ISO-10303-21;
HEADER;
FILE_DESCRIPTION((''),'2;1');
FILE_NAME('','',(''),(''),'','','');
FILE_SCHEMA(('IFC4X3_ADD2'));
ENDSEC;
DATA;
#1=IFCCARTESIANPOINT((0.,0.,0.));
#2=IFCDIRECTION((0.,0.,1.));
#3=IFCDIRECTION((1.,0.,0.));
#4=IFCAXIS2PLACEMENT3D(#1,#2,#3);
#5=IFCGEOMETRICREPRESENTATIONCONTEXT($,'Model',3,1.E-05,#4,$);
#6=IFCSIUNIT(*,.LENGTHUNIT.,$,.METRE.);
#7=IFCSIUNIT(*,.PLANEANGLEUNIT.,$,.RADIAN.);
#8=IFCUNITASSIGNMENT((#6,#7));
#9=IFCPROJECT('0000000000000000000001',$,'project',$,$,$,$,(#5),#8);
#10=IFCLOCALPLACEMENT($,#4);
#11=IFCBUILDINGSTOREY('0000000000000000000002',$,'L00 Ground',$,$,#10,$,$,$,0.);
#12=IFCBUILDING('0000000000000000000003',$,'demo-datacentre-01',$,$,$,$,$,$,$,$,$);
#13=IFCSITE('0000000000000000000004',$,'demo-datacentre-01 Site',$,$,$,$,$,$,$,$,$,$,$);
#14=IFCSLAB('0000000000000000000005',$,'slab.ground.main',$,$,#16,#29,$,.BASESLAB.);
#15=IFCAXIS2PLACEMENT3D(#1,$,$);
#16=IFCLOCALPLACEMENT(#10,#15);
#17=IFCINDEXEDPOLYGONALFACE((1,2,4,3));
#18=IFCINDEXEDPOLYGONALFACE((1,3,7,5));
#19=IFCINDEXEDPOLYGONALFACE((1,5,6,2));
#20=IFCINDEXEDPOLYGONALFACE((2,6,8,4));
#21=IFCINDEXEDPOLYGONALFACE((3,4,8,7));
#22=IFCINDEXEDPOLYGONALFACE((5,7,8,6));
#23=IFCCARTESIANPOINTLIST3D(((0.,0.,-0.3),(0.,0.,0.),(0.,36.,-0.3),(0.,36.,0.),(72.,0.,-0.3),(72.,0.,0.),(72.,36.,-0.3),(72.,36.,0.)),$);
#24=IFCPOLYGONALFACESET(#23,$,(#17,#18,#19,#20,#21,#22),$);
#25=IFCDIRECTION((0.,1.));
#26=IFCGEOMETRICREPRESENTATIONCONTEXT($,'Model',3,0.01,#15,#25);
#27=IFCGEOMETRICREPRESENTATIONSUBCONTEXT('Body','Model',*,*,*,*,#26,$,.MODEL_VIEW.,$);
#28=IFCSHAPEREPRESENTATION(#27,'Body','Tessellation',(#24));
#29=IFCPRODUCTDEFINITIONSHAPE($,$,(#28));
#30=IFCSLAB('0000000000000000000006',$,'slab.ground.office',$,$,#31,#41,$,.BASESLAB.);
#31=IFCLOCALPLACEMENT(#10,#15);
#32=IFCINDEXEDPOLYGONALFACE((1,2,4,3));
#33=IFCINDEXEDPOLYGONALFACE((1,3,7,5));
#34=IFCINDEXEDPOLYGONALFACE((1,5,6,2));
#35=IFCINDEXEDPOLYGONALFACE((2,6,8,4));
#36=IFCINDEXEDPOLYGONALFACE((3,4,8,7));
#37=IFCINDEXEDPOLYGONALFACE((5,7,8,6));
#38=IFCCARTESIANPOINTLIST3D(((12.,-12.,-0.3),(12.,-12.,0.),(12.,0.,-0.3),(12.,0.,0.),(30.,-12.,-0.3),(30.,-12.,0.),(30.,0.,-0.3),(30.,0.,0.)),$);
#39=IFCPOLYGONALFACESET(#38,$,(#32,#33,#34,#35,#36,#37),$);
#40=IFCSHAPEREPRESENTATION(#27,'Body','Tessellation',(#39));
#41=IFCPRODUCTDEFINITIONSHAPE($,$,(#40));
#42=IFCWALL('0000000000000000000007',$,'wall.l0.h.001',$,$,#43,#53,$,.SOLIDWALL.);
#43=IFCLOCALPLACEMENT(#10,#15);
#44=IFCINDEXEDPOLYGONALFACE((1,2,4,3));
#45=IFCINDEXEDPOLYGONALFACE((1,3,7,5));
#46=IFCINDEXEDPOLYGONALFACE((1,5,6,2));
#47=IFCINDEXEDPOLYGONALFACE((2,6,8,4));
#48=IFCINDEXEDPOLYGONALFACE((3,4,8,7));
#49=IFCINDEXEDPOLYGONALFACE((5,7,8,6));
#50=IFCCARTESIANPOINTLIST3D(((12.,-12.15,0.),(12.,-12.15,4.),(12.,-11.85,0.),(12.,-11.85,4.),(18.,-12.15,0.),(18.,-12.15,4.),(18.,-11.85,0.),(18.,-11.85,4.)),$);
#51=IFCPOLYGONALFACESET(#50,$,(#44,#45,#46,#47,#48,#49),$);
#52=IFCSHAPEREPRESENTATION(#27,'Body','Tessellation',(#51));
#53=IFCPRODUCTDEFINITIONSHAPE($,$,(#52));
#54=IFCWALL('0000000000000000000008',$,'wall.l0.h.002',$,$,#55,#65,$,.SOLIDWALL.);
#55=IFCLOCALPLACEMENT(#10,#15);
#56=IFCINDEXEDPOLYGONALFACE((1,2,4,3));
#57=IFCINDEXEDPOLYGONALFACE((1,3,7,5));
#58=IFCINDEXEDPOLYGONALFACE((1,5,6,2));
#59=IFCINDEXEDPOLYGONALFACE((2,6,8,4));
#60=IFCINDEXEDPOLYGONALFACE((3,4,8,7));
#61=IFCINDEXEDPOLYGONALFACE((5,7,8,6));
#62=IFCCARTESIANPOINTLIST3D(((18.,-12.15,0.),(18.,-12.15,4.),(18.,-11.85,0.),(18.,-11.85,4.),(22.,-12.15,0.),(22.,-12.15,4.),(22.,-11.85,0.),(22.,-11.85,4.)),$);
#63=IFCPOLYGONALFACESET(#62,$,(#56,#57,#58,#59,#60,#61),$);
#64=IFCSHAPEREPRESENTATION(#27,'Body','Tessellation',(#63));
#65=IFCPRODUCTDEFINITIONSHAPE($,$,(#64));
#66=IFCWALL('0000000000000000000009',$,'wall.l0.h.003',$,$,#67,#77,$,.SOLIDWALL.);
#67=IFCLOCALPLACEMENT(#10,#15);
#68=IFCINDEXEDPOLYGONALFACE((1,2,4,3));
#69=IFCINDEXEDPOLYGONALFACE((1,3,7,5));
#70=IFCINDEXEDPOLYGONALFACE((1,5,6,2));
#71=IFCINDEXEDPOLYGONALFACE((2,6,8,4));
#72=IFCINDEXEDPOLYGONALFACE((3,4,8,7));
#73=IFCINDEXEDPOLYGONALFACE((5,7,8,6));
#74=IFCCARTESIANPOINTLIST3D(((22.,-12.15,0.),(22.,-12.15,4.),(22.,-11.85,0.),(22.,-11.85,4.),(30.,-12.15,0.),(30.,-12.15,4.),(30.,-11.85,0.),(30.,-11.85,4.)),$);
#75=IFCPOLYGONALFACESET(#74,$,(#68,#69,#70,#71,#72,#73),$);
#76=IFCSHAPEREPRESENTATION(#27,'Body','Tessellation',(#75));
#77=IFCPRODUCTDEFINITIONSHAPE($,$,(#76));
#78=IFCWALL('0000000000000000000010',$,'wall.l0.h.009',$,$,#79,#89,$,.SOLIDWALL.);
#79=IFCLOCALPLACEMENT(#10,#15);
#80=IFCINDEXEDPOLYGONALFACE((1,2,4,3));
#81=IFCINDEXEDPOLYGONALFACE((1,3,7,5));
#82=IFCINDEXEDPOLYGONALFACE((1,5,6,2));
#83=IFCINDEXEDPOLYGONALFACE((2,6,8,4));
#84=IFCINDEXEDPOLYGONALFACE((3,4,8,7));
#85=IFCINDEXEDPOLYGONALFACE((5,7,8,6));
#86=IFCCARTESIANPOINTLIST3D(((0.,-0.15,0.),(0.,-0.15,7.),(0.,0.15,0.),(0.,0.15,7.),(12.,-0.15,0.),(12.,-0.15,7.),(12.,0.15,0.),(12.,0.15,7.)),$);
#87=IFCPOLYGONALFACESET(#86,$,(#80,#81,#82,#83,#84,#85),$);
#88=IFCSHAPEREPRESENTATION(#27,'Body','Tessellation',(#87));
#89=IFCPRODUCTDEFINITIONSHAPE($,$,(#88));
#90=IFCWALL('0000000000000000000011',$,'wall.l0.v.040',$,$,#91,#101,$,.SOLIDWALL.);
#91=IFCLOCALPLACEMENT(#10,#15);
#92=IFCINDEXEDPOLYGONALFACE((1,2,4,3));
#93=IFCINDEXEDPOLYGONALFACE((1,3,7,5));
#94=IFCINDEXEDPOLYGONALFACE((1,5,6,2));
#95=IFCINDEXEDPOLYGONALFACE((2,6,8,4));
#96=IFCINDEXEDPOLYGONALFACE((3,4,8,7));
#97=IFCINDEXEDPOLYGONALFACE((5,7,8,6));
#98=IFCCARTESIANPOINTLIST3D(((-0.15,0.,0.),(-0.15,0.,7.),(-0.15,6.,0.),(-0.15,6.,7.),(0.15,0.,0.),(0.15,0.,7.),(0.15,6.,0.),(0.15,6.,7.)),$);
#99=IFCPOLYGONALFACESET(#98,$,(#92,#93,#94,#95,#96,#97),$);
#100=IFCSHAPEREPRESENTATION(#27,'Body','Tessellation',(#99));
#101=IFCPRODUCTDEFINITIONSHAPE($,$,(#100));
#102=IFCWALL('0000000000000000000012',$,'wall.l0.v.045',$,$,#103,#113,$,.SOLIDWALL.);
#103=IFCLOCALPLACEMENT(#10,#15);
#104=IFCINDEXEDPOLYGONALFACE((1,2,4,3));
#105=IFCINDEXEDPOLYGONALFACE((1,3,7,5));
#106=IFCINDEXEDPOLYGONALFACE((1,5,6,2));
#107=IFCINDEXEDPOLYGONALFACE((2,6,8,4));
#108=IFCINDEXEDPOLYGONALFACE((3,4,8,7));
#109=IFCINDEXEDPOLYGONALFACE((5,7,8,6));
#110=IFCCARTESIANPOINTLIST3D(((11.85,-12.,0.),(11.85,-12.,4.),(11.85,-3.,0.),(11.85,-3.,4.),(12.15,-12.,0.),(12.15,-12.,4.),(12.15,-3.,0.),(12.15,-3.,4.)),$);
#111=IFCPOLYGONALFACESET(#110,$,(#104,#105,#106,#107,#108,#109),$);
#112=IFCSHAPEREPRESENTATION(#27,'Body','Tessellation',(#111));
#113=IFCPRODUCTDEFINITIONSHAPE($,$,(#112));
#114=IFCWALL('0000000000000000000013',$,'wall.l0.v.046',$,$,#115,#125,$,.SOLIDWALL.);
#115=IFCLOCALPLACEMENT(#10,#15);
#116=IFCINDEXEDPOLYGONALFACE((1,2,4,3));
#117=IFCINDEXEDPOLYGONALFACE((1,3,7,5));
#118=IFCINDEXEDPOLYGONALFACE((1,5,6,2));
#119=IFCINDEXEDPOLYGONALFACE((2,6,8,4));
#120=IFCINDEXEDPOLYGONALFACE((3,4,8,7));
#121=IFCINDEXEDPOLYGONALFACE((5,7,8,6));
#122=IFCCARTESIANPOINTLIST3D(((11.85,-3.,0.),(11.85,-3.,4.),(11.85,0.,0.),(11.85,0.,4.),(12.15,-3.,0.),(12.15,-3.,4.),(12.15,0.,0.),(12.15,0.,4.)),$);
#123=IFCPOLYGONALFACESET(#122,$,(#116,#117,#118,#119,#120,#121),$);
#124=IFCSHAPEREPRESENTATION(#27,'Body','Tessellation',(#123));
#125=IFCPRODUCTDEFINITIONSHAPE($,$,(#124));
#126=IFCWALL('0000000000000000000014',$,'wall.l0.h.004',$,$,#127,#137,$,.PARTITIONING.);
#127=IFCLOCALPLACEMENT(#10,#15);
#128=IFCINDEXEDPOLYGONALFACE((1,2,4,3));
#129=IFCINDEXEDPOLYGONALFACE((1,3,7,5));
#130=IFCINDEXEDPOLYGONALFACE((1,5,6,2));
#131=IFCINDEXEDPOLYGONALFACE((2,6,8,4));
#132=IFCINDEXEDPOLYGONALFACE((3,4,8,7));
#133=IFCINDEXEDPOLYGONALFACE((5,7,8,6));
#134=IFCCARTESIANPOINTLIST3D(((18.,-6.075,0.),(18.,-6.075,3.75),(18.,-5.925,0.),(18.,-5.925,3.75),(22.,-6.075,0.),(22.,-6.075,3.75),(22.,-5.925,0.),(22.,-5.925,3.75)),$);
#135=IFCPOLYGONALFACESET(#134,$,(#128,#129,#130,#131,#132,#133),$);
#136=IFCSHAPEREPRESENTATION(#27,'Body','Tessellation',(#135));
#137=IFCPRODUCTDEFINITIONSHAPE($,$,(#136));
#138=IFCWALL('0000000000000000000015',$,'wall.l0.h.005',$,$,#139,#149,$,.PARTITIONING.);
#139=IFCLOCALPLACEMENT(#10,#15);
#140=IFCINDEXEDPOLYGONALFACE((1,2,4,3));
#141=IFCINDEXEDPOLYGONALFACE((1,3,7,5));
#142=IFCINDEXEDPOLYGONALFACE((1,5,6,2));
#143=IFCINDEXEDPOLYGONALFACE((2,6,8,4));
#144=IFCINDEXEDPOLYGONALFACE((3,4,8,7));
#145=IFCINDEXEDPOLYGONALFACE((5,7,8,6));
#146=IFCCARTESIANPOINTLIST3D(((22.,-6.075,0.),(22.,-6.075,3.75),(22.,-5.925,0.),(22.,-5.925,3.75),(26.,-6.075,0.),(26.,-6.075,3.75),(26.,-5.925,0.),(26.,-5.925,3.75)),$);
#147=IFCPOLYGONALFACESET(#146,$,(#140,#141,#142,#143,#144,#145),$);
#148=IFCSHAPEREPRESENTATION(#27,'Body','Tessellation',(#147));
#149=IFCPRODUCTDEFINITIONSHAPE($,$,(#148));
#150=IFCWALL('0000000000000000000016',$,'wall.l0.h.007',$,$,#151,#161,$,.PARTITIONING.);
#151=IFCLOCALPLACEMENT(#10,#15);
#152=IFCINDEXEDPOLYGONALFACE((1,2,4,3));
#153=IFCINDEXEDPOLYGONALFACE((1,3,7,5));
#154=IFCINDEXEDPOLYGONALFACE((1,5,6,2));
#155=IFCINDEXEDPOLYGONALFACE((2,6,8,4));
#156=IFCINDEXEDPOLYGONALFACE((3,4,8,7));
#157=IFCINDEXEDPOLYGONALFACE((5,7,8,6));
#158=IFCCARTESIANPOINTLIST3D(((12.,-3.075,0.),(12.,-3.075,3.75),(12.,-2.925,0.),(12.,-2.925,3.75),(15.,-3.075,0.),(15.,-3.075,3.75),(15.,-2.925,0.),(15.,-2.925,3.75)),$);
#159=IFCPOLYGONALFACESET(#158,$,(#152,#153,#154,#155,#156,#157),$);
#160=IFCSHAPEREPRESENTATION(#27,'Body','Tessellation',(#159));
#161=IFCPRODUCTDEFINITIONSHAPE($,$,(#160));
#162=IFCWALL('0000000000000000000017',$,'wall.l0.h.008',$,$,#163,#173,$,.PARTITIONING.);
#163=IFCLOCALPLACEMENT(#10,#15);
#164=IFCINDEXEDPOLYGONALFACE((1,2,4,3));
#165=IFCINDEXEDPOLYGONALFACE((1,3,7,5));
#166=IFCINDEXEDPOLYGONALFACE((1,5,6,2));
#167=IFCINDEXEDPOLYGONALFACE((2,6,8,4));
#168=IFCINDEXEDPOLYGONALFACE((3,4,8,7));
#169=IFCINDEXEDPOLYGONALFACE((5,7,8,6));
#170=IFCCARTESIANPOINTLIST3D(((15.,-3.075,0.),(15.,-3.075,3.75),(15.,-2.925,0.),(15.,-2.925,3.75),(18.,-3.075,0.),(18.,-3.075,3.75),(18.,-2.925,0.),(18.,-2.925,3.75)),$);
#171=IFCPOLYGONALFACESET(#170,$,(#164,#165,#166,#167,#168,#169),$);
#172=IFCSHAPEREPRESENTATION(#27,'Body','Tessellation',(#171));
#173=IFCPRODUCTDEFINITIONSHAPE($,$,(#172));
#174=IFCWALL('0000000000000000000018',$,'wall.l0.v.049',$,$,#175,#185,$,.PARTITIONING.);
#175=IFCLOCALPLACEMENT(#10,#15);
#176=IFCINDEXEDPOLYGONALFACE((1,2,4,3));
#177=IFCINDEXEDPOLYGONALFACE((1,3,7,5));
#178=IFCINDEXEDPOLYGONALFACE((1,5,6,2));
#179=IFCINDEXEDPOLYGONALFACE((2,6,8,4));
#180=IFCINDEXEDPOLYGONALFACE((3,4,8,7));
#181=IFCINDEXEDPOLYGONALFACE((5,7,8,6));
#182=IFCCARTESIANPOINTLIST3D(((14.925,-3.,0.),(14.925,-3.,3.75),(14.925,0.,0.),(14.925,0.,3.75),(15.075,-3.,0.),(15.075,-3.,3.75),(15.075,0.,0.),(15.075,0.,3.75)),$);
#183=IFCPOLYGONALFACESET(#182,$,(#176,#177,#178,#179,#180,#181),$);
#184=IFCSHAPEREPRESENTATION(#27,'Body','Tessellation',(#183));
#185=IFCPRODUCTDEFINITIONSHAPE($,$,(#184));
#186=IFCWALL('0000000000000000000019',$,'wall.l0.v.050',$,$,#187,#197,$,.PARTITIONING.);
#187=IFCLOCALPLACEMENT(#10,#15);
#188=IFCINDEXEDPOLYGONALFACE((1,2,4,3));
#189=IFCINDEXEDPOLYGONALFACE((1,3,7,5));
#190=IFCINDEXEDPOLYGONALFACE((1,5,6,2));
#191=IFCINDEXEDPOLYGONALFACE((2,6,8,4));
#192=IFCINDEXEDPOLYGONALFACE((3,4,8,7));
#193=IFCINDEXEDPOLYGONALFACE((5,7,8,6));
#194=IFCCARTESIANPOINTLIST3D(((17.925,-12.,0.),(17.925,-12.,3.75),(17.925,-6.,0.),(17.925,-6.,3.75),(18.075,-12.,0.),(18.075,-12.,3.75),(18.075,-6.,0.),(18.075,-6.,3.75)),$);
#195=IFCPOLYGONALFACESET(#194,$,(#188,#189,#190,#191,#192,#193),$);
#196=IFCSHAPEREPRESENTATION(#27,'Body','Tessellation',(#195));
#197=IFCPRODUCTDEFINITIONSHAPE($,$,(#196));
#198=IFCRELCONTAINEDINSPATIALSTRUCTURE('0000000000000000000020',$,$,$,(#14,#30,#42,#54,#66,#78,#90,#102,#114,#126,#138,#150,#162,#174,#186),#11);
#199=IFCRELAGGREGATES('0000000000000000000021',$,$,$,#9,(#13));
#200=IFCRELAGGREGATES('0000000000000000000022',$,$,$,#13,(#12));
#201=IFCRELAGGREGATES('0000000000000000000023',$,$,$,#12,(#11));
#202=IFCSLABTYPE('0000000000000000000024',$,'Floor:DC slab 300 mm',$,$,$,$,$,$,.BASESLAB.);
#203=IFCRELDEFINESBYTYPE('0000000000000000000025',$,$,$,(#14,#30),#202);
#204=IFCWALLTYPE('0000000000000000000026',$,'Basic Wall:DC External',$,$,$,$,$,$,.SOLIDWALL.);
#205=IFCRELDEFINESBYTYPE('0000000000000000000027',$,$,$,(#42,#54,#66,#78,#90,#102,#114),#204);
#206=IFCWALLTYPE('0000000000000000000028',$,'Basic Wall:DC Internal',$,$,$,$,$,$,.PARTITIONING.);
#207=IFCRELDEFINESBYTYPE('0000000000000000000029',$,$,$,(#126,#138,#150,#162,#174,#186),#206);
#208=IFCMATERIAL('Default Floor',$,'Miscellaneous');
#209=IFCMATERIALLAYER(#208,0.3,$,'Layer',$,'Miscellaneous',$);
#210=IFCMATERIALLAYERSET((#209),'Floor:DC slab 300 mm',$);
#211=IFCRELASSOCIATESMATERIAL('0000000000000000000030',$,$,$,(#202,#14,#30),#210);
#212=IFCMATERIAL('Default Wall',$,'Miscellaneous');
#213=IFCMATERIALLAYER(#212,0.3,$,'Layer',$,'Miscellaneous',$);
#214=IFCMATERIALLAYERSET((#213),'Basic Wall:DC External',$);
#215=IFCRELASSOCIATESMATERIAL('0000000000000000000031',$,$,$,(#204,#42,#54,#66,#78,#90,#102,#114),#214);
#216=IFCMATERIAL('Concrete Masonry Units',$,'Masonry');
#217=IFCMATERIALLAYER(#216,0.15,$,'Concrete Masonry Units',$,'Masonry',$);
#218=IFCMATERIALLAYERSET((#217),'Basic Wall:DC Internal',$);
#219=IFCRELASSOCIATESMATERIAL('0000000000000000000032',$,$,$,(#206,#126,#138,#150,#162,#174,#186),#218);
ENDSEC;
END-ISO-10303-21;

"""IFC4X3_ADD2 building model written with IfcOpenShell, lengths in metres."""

from ifc_helpers import new_model, si_unit, direction, frame, frame_2d, origin, origin_with_axes, origin_2d_with_axis, place, context, subcontext, project, spatial, rectangle, extrude, material, layer, layer_set, layer_usage, type_object, element, save


model = new_model("IFC4X3_ADD2")

# Units and contexts
model_context_1 = context("Model", 3, precision=0.01, world=origin(), true_north=direction((0.0, 1.0)))
model_context_2 = context("Model", 3, precision=1e-05, world=origin_with_axes())
body_context = subcontext(model_context_1, "Body", "Model", "MODEL_VIEW")
ifc_project = project(units=[si_unit("LENGTHUNIT", "METRE"), si_unit("PLANEANGLEUNIT", "RADIAN")], contexts=[model_context_2])

# Site, building, storey
site = spatial("IfcSite", under=ifc_project, Name="demo-datacentre-01 Site")
building = spatial("IfcBuilding", under=site, Name="demo-datacentre-01")
storey_placement = place(None, origin_with_axes())
storey = spatial("IfcBuildingStorey", under=building, at=storey_placement, Name="L00 Ground", Elevation=0.0)

# Slabs
ifc_material_1 = material(Name="Default Floor", Category="Miscellaneous")
ifc_layer_1 = layer(ifc_material_1, 0.3, Name="Layer", Category="Miscellaneous")
ifc_layer_set_1 = layer_set([ifc_layer_1], Name="Floor:DC slab 300 mm")
ifc_layer_usage_1 = layer_usage(ifc_layer_set_1, "AXIS3", "POSITIVE", 0.0)
slab_type = type_object("IfcSlabType", Name="Floor:DC slab 300 mm", PredefinedType="BASESLAB", material=ifc_layer_set_1)
placement_1 = place(None, origin())
placement_2 = place(placement_1, origin())
placement_3 = place(placement_2, origin())
slab_1_placement = place(placement_3, origin())
element("IfcSlab", 1, at=slab_1_placement, inside=storey, type_object=slab_type, material=ifc_layer_usage_1, Name="slab.ground.main", PredefinedType="BASESLAB", context=body_context, shape_type="SweptSolid", body=[
    extrude(rectangle(XDim=36.0, YDim=72.0, at=origin_2d_with_axis()), frame((36.0, 18.0, 0.0), z_axis=(0.0, 0.0, -1.0), x_axis=(0.0, 1.0, 0.0)), (0.0, 0.0, 1.0), 0.3),
])
ifc_layer_usage_2 = layer_usage(ifc_layer_set_1, "AXIS3", "POSITIVE", 0.0)
slab_2_placement = place(placement_3, origin())
element("IfcSlab", 2, at=slab_2_placement, inside=storey, type_object=slab_type, material=ifc_layer_usage_2, Name="slab.ground.office", PredefinedType="BASESLAB", context=body_context, shape_type="SweptSolid", body=[
    extrude(rectangle(XDim=12.0, YDim=18.0, at=frame_2d((0.0, 0.0), x_axis=(1.0, 0.0))), frame((21.0, -6.0, 0.0), z_axis=(0.0, 0.0, -1.0), x_axis=(0.0, 1.0, 0.0)), (0.0, 0.0, 1.0), 0.3),
])

# Walls
ifc_material_2 = material(Name="Default Wall", Category="Miscellaneous")
ifc_layer_2 = layer(ifc_material_2, 0.3, Name="Layer", Category="Miscellaneous")
ifc_layer_set_2 = layer_set([ifc_layer_2], Name="Basic Wall:DC External")
wall_type_1 = type_object("IfcWallType", Name="Basic Wall:DC External", PredefinedType="SOLIDWALL", material=ifc_layer_set_2)
wall_1_placement = place(placement_3, frame((12.0, -12.0, 0.0)))
element("IfcWall", 3, at=wall_1_placement, inside=storey, type_object=wall_type_1, material=ifc_layer_set_2, Name="wall.l0.h.001", PredefinedType="SOLIDWALL", context=body_context, shape_type="SweptSolid", body=[
    extrude(rectangle(XDim=6.0, YDim=0.3, at=frame_2d((3.0, 0.0), x_axis=(-1.0, 0.0))), origin(), (0.0, 0.0, 1.0), 4.0),
])
wall_2_placement = place(placement_3, frame((18.0, -12.0, 0.0)))
element("IfcWall", 4, at=wall_2_placement, inside=storey, type_object=wall_type_1, material=ifc_layer_set_2, Name="wall.l0.h.002", PredefinedType="SOLIDWALL", context=body_context, shape_type="SweptSolid", body=[
    extrude(rectangle(XDim=4.0, YDim=0.3, at=frame_2d((2.0, 0.0), x_axis=(-1.0, 0.0))), origin(), (0.0, 0.0, 1.0), 4.0),
])
wall_3_placement = place(placement_3, frame((22.0, -12.0, 0.0)))
element("IfcWall", 5, at=wall_3_placement, inside=storey, type_object=wall_type_1, material=ifc_layer_set_2, Name="wall.l0.h.003", PredefinedType="SOLIDWALL", context=body_context, shape_type="SweptSolid", body=[
    extrude(rectangle(XDim=8.0, YDim=0.3, at=frame_2d((4.0, 0.0), x_axis=(-1.0, 0.0))), origin(), (0.0, 0.0, 1.0), 4.0),
])
wall_4_placement = place(placement_3, origin())
element("IfcWall", 6, at=wall_4_placement, inside=storey, type_object=wall_type_1, material=ifc_layer_set_2, Name="wall.l0.h.009", PredefinedType="SOLIDWALL", context=body_context, shape_type="SweptSolid", body=[
    extrude(rectangle(XDim=12.0, YDim=0.3, at=frame_2d((6.0, 0.0), x_axis=(-1.0, 0.0))), origin(), (0.0, 0.0, 1.0), 7.0),
])
wall_5_placement = place(placement_3, frame((0.0, 0.0, 0.0), z_axis=(0.0, 0.0, 1.0), x_axis=(0.0, 1.0, 0.0)))
element("IfcWall", 7, at=wall_5_placement, inside=storey, type_object=wall_type_1, material=ifc_layer_set_2, Name="wall.l0.v.040", PredefinedType="SOLIDWALL", context=body_context, shape_type="SweptSolid", body=[
    extrude(rectangle(XDim=6.0, YDim=0.3, at=frame_2d((3.0, 0.0), x_axis=(-1.0, 0.0))), origin(), (0.0, 0.0, 1.0), 7.0),
])
wall_6_placement = place(placement_3, frame((12.0, -12.0, 0.0), z_axis=(0.0, 0.0, 1.0), x_axis=(0.0, 1.0, 0.0)))
element("IfcWall", 8, at=wall_6_placement, inside=storey, type_object=wall_type_1, material=ifc_layer_set_2, Name="wall.l0.v.045", PredefinedType="SOLIDWALL", context=body_context, shape_type="SweptSolid", body=[
    extrude(rectangle(XDim=9.0, YDim=0.3, at=frame_2d((4.5, 0.0), x_axis=(-1.0, 0.0))), origin(), (0.0, 0.0, 1.0), 4.0),
])
wall_7_placement = place(placement_3, frame((12.0, -3.0, 0.0), z_axis=(0.0, 0.0, 1.0), x_axis=(0.0, 1.0, 0.0)))
element("IfcWall", 9, at=wall_7_placement, inside=storey, type_object=wall_type_1, material=ifc_layer_set_2, Name="wall.l0.v.046", PredefinedType="SOLIDWALL", context=body_context, shape_type="SweptSolid", body=[
    extrude(rectangle(XDim=3.0, YDim=0.3, at=frame_2d((1.5, 0.0), x_axis=(-1.0, 0.0))), origin(), (0.0, 0.0, 1.0), 4.0),
])
ifc_material_3 = material(Name="Concrete Masonry Units", Category="Masonry")
ifc_layer_3 = layer(ifc_material_3, 0.15, Name="Concrete Masonry Units", Category="Masonry")
ifc_layer_set_3 = layer_set([ifc_layer_3], Name="Basic Wall:DC Internal")
wall_type_2 = type_object("IfcWallType", Name="Basic Wall:DC Internal", PredefinedType="PARTITIONING", material=ifc_layer_set_3)
wall_8_placement = place(placement_3, frame((18.0, -6.0, 0.0)))
element("IfcWall", 10, at=wall_8_placement, inside=storey, type_object=wall_type_2, material=ifc_layer_set_3, Name="wall.l0.h.004", PredefinedType="PARTITIONING", context=body_context, shape_type="SweptSolid", body=[
    extrude(rectangle(XDim=4.0, YDim=0.15, at=frame_2d((2.0, 0.0), x_axis=(-1.0, 0.0))), origin(), (0.0, 0.0, 1.0), 3.75),
])
wall_9_placement = place(placement_3, frame((22.0, -6.0, 0.0)))
element("IfcWall", 11, at=wall_9_placement, inside=storey, type_object=wall_type_2, material=ifc_layer_set_3, Name="wall.l0.h.005", PredefinedType="PARTITIONING", context=body_context, shape_type="SweptSolid", body=[
    extrude(rectangle(XDim=4.0, YDim=0.15, at=frame_2d((2.0, 0.0), x_axis=(-1.0, 0.0))), origin(), (0.0, 0.0, 1.0), 3.75),
])
for number, where, name in (
    (12, (12.0, -3.0, 0.0), "wall.l0.h.007"),
    (13, (15.0, -3.0, 0.0), "wall.l0.h.008"),
):
    element("IfcWall", number, at=place(placement_3, frame(where)), inside=storey, type_object=wall_type_2, material=ifc_layer_set_3, Name=name, PredefinedType="PARTITIONING", context=body_context, shape_type="SweptSolid", body=[
        extrude(rectangle(XDim=3.0, YDim=0.15, at=frame_2d((1.5, 0.0), x_axis=(-1.0, 0.0))), origin(), (0.0, 0.0, 1.0), 3.75),
    ])
wall_10_placement = place(placement_3, frame((15.0, -3.0, 0.0), z_axis=(0.0, 0.0, 1.0), x_axis=(0.0, 1.0, 0.0)))
element("IfcWall", 14, at=wall_10_placement, inside=storey, type_object=wall_type_2, material=ifc_layer_set_3, Name="wall.l0.v.049", PredefinedType="PARTITIONING", context=body_context, shape_type="SweptSolid", body=[
    extrude(rectangle(XDim=3.0, YDim=0.15, at=frame_2d((1.5, 0.0), x_axis=(-1.0, 0.0))), origin(), (0.0, 0.0, 1.0), 3.75),
])
wall_11_placement = place(placement_3, frame((18.0, -12.0, 0.0), z_axis=(0.0, 0.0, 1.0), x_axis=(0.0, 1.0, 0.0)))
element("IfcWall", 15, at=wall_11_placement, inside=storey, type_object=wall_type_2, material=ifc_layer_set_3, Name="wall.l0.v.050", PredefinedType="PARTITIONING", context=body_context, shape_type="SweptSolid", body=[
    extrude(rectangle(XDim=6.0, YDim=0.15, at=frame_2d((3.0, 0.0), x_axis=(-1.0, 0.0))), origin(), (0.0, 0.0, 1.0), 3.75),
])

save(model, "model.ifc")
